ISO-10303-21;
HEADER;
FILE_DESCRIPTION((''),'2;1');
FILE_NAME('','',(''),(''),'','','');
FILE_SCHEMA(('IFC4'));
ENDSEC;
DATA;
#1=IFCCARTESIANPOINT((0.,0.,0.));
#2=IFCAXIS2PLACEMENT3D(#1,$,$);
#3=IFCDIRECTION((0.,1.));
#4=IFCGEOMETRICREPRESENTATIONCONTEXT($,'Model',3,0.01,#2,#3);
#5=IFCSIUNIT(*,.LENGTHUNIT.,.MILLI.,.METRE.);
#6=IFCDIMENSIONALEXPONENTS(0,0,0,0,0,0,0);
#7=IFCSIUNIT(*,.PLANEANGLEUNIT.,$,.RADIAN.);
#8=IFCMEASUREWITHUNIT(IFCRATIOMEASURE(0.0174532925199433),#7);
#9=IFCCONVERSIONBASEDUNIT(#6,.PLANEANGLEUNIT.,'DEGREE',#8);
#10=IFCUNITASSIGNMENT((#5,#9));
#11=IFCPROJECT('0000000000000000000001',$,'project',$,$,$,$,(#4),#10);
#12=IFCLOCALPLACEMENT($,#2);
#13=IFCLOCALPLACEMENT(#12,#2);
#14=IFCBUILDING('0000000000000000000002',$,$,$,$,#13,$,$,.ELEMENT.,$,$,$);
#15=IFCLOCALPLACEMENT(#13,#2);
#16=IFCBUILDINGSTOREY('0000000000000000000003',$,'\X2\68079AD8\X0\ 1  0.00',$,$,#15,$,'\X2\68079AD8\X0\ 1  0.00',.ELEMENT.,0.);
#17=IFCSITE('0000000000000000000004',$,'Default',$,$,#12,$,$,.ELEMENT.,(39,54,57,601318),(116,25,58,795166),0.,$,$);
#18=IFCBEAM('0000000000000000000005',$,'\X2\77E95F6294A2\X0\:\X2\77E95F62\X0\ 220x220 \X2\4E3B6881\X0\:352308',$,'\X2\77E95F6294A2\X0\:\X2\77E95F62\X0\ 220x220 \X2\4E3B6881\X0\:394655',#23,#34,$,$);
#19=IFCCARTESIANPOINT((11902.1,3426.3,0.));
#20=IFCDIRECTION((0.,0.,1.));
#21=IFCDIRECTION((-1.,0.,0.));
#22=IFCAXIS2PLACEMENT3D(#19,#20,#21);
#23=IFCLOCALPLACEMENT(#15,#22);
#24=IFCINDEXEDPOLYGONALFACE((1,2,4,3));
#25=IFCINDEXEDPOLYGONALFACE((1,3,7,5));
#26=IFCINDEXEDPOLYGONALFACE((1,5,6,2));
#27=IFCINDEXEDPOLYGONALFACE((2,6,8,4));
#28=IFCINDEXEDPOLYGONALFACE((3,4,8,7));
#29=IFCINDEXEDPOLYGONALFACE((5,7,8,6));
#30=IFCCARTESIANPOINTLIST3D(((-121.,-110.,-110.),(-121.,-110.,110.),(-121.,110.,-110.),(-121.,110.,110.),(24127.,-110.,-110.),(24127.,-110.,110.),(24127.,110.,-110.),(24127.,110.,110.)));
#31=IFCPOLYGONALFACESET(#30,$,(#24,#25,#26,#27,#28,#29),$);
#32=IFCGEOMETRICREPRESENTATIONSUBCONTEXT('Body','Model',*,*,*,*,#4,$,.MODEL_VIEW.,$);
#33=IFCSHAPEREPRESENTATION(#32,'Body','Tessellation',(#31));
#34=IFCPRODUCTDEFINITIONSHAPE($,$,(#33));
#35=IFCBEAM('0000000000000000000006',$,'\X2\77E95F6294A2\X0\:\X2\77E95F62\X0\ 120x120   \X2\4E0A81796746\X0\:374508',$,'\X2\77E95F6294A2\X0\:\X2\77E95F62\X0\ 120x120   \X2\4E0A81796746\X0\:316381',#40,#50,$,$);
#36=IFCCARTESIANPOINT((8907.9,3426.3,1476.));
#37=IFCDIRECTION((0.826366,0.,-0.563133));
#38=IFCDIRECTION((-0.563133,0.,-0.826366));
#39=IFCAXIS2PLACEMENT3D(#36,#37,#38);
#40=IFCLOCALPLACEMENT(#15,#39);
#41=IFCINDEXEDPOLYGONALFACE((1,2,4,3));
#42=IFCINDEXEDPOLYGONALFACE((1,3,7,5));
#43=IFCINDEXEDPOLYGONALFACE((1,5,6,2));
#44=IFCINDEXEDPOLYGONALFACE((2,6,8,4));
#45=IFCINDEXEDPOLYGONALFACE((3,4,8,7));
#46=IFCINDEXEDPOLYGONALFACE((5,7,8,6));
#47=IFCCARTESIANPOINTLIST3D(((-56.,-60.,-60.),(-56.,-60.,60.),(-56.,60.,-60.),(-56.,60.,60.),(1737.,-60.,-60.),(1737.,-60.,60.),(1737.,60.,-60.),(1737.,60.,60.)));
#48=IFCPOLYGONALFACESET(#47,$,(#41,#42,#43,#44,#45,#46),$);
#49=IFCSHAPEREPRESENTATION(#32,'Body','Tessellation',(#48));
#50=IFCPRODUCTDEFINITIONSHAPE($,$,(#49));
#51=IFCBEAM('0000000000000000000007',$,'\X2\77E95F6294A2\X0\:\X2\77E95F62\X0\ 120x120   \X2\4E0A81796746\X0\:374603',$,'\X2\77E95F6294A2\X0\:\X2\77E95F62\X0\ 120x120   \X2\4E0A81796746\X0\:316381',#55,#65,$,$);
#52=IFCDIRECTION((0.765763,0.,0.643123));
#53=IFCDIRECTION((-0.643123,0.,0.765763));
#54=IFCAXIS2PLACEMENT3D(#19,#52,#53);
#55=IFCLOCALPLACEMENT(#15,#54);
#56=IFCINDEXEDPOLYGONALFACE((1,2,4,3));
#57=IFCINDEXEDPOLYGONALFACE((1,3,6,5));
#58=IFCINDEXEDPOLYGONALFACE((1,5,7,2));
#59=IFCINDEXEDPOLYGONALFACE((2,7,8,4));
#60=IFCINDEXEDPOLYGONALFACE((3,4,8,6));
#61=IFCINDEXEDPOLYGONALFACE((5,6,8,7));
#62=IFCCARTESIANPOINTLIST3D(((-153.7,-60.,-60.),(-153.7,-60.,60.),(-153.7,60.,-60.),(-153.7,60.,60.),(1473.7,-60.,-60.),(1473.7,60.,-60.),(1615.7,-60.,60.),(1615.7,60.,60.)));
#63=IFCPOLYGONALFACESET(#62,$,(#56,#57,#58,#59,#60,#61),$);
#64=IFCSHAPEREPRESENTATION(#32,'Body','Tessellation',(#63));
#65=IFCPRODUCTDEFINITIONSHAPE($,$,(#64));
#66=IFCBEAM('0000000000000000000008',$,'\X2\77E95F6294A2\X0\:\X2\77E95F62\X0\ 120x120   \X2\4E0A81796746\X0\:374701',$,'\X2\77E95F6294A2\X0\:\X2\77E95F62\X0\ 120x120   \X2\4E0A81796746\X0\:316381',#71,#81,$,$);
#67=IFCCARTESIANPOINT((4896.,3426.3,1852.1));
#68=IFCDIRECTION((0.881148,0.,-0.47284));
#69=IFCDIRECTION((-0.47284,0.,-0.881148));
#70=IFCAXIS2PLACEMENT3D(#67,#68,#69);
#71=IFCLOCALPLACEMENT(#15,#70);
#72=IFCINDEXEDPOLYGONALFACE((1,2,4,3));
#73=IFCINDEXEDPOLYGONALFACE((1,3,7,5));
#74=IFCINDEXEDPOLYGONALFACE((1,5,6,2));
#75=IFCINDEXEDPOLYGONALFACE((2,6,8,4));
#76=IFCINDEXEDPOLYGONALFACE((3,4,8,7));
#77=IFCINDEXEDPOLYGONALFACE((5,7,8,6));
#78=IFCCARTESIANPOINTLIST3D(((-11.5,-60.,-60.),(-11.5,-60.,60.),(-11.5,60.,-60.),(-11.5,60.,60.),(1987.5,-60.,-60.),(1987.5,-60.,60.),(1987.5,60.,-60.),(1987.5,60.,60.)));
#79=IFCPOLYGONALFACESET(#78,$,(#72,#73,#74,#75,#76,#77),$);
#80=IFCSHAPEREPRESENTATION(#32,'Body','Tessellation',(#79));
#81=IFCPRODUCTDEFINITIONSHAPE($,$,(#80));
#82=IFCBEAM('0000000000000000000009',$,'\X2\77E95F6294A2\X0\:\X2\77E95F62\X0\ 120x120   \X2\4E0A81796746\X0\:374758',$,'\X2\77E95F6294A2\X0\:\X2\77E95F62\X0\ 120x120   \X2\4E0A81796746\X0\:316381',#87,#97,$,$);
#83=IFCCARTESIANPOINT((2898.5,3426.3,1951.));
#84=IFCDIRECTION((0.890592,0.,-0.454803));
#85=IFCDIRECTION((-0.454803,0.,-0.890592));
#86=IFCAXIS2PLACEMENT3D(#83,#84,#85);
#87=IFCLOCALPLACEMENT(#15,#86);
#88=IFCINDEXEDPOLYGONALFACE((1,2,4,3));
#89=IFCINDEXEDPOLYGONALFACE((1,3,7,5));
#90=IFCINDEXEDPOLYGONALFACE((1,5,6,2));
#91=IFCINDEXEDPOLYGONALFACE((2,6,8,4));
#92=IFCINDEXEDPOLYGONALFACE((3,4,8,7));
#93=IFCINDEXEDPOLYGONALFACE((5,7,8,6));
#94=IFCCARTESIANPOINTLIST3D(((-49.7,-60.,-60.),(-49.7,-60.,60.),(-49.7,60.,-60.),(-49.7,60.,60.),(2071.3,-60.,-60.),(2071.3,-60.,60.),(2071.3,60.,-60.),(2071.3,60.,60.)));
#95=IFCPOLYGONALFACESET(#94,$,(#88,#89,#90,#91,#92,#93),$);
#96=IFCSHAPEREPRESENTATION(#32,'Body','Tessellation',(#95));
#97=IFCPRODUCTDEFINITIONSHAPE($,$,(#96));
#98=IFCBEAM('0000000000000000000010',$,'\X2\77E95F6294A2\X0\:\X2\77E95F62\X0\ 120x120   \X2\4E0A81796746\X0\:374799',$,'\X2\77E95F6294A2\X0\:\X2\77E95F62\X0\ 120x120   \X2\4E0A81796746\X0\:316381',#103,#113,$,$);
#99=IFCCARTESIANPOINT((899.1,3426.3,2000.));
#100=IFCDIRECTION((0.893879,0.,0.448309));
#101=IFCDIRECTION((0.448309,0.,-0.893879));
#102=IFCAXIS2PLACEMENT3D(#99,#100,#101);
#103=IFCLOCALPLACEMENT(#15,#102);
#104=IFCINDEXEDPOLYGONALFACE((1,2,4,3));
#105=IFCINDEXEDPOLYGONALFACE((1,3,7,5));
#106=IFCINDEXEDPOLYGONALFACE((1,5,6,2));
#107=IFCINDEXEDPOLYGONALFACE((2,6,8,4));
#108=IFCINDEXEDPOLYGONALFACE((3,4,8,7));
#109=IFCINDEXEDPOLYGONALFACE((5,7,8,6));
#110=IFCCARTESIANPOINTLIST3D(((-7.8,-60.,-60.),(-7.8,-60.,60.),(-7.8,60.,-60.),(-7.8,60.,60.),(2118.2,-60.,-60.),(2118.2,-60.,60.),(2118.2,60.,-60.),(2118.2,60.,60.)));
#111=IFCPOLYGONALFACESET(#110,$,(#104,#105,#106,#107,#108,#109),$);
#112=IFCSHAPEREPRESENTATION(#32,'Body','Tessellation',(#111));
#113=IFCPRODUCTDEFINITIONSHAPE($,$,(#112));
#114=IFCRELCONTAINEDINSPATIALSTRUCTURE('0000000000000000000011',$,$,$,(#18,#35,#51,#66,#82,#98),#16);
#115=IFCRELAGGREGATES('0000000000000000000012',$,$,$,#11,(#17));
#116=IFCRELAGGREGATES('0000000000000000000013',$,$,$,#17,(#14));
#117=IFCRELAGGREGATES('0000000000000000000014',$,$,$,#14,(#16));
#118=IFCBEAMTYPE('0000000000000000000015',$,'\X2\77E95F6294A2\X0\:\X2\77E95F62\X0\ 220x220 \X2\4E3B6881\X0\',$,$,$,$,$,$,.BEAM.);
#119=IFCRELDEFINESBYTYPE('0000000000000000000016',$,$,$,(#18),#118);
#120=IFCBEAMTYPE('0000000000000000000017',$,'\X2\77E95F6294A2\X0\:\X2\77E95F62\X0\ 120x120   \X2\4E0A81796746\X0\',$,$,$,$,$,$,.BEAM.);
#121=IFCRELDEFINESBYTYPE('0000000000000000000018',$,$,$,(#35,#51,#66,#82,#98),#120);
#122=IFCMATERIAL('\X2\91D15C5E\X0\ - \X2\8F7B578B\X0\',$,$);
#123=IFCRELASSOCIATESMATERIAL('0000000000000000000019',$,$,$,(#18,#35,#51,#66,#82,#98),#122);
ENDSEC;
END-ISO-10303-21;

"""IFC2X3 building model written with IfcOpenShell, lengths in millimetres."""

from ifc_helpers import new_model, entity, si_unit, converted_unit, direction, frame, frame_2d, origin, place, context, subcontext, project, spatial, rectangle, extrude, clip, halfspace, material, type_object, element, save


model = new_model("IFC2X3")

# Units and contexts
model_context = context("Model", 3, precision=0.01, world=origin(), true_north=direction((0.0, 1.0)))
body_context = subcontext(model_context, "Body", "Model", "MODEL_VIEW")
ifc_project = project(units=[si_unit("LENGTHUNIT", "METRE", prefix="MILLI"), converted_unit("PLANEANGLEUNIT", "DEGREE", entity("IfcRatioMeasure", 0.0174532925199433), si_unit("PLANEANGLEUNIT", "RADIAN"), dimensions=[0, 0, 0, 0, 0, 0, 0])], contexts=[model_context])

# Site, building, storey
site_placement = place(None, origin())
site = spatial("IfcSite", under=ifc_project, at=site_placement, Name="Default", CompositionType="ELEMENT", RefLatitude=(39, 54, 57, 601318), RefLongitude=(116, 25, 58, 795166), RefElevation=0.0)
building_placement = place(site_placement, origin())
building = spatial("IfcBuilding", under=site, at=building_placement, CompositionType="ELEMENT")
storey_placement = place(building_placement, origin())
storey = spatial("IfcBuildingStorey", under=building, at=storey_placement, Name="标高 1  0.00", LongName="标高 1  0.00", CompositionType="ELEMENT", Elevation=0.0)

# Shared definitions
ifc_material_1 = material(Name="金属 - 轻型")

# Beams
beam_type_1 = type_object("IfcBeamType", Name="矩形钢:矩形 220x220 主梁", PredefinedType="BEAM")
beam_1_placement = place(storey_placement, frame((11902.1, 3426.3, 0.0), z_axis=(0.0, 0.0, 1.0), x_axis=(-1.0, 0.0, 0.0)))
element("IfcBeam", 1, at=beam_1_placement, inside=storey, type_object=beam_type_1, material=ifc_material_1, Name="矩形钢:矩形 220x220 主梁:352308", ObjectType="矩形钢:矩形 220x220 主梁:394655", context=body_context, shape_type="SweptSolid", body=[
    extrude(rectangle(XDim=220.0, YDim=220.0, at=frame_2d((0.0, 0.0), x_axis=(1.0, 0.0))), frame((-121.0, 0.0, 0.0), z_axis=(1.0, 0.0, 0.0), x_axis=(0.0, 0.0, -1.0)), (0.0, 0.0, 1.0), 24248.0),
])
beam_type_2 = type_object("IfcBeamType", Name="矩形钢:矩形 120x120   上腹杆", PredefinedType="BEAM")
beam_2_placement = place(storey_placement, frame((8907.9, 3426.3, 1476.0), z_axis=(0.826366, 0.0, -0.563133), x_axis=(-0.563133, 0.0, -0.826366)))
element("IfcBeam", 2, at=beam_2_placement, inside=storey, type_object=beam_type_2, material=ifc_material_1, Name="矩形钢:矩形 120x120   上腹杆:374508", ObjectType="矩形钢:矩形 120x120   上腹杆:316381", context=body_context, shape_type="SweptSolid", body=[
    extrude(rectangle(XDim=120.0, YDim=120.0, at=frame_2d((0.0, 0.0), x_axis=(1.0, 0.0))), frame((-56.0, 0.0, 0.0), z_axis=(1.0, 0.0, 0.0), x_axis=(0.0, 0.0, -1.0)), (0.0, 0.0, 1.0), 1793.0),
])
beam_3_placement = place(storey_placement, frame((11902.1, 3426.3, 0.0), z_axis=(0.765763, 0.0, 0.643123), x_axis=(-0.643123, 0.0, 0.765763)))
element("IfcBeam", 3, at=beam_3_placement, inside=storey, type_object=beam_type_2, material=ifc_material_1, Name="矩形钢:矩形 120x120   上腹杆:374603", ObjectType="矩形钢:矩形 120x120   上腹杆:316381", context=body_context, shape_type="Clipping", body=[
    clip(extrude(rectangle(XDim=120.0, YDim=120.0, at=frame_2d((0.0, 0.0), x_axis=(1.0, 0.0))), frame((-153.7, 0.0, 0.0), z_axis=(1.0, 0.0, 0.0), x_axis=(0.0, 0.0, -1.0)), (0.0, 0.0, 1.0), 1769.4), halfspace(frame((1615.7, 0.0, 60.0), z_axis=(0.645598, 0.0, -0.763678), x_axis=(0.763678, 0.0, 0.645598)), False)),
])
beam_4_placement = place(storey_placement, frame((4896.0, 3426.3, 1852.1), z_axis=(0.881148, 0.0, -0.47284), x_axis=(-0.47284, 0.0, -0.881148)))
element("IfcBeam", 4, at=beam_4_placement, inside=storey, type_object=beam_type_2, material=ifc_material_1, Name="矩形钢:矩形 120x120   上腹杆:374701", ObjectType="矩形钢:矩形 120x120   上腹杆:316381", context=body_context, shape_type="SweptSolid", body=[
    extrude(rectangle(XDim=120.0, YDim=120.0, at=frame_2d((0.0, 0.0), x_axis=(1.0, 0.0))), frame((-11.5, 0.0, 0.0), z_axis=(1.0, 0.0, 0.0), x_axis=(0.0, 0.0, -1.0)), (0.0, 0.0, 1.0), 1999.0),
])
beam_5_placement = place(storey_placement, frame((2898.5, 3426.3, 1951.0), z_axis=(0.890592, 0.0, -0.454803), x_axis=(-0.454803, 0.0, -0.890592)))
element("IfcBeam", 5, at=beam_5_placement, inside=storey, type_object=beam_type_2, material=ifc_material_1, Name="矩形钢:矩形 120x120   上腹杆:374758", ObjectType="矩形钢:矩形 120x120   上腹杆:316381", context=body_context, shape_type="SweptSolid", body=[
    extrude(rectangle(XDim=120.0, YDim=120.0, at=frame_2d((0.0, 0.0), x_axis=(1.0, 0.0))), frame((-49.7, 0.0, 0.0), z_axis=(1.0, 0.0, 0.0), x_axis=(0.0, 0.0, -1.0)), (0.0, 0.0, 1.0), 2121.0),
])
beam_6_placement = place(storey_placement, frame((899.1, 3426.3, 2000.0), z_axis=(0.893879, 0.0, 0.448309), x_axis=(0.448309, 0.0, -0.893879)))
element("IfcBeam", 6, at=beam_6_placement, inside=storey, type_object=beam_type_2, material=ifc_material_1, Name="矩形钢:矩形 120x120   上腹杆:374799", ObjectType="矩形钢:矩形 120x120   上腹杆:316381", context=body_context, shape_type="SweptSolid", body=[
    extrude(rectangle(XDim=120.0, YDim=120.0, at=frame_2d((0.0, 0.0), x_axis=(1.0, 0.0))), frame((-7.8, 0.0, 0.0), z_axis=(1.0, 0.0, 0.0), x_axis=(0.0, 0.0, -1.0)), (0.0, 0.0, 1.0), 2126.0),
])

save(model, "model.ifc")
